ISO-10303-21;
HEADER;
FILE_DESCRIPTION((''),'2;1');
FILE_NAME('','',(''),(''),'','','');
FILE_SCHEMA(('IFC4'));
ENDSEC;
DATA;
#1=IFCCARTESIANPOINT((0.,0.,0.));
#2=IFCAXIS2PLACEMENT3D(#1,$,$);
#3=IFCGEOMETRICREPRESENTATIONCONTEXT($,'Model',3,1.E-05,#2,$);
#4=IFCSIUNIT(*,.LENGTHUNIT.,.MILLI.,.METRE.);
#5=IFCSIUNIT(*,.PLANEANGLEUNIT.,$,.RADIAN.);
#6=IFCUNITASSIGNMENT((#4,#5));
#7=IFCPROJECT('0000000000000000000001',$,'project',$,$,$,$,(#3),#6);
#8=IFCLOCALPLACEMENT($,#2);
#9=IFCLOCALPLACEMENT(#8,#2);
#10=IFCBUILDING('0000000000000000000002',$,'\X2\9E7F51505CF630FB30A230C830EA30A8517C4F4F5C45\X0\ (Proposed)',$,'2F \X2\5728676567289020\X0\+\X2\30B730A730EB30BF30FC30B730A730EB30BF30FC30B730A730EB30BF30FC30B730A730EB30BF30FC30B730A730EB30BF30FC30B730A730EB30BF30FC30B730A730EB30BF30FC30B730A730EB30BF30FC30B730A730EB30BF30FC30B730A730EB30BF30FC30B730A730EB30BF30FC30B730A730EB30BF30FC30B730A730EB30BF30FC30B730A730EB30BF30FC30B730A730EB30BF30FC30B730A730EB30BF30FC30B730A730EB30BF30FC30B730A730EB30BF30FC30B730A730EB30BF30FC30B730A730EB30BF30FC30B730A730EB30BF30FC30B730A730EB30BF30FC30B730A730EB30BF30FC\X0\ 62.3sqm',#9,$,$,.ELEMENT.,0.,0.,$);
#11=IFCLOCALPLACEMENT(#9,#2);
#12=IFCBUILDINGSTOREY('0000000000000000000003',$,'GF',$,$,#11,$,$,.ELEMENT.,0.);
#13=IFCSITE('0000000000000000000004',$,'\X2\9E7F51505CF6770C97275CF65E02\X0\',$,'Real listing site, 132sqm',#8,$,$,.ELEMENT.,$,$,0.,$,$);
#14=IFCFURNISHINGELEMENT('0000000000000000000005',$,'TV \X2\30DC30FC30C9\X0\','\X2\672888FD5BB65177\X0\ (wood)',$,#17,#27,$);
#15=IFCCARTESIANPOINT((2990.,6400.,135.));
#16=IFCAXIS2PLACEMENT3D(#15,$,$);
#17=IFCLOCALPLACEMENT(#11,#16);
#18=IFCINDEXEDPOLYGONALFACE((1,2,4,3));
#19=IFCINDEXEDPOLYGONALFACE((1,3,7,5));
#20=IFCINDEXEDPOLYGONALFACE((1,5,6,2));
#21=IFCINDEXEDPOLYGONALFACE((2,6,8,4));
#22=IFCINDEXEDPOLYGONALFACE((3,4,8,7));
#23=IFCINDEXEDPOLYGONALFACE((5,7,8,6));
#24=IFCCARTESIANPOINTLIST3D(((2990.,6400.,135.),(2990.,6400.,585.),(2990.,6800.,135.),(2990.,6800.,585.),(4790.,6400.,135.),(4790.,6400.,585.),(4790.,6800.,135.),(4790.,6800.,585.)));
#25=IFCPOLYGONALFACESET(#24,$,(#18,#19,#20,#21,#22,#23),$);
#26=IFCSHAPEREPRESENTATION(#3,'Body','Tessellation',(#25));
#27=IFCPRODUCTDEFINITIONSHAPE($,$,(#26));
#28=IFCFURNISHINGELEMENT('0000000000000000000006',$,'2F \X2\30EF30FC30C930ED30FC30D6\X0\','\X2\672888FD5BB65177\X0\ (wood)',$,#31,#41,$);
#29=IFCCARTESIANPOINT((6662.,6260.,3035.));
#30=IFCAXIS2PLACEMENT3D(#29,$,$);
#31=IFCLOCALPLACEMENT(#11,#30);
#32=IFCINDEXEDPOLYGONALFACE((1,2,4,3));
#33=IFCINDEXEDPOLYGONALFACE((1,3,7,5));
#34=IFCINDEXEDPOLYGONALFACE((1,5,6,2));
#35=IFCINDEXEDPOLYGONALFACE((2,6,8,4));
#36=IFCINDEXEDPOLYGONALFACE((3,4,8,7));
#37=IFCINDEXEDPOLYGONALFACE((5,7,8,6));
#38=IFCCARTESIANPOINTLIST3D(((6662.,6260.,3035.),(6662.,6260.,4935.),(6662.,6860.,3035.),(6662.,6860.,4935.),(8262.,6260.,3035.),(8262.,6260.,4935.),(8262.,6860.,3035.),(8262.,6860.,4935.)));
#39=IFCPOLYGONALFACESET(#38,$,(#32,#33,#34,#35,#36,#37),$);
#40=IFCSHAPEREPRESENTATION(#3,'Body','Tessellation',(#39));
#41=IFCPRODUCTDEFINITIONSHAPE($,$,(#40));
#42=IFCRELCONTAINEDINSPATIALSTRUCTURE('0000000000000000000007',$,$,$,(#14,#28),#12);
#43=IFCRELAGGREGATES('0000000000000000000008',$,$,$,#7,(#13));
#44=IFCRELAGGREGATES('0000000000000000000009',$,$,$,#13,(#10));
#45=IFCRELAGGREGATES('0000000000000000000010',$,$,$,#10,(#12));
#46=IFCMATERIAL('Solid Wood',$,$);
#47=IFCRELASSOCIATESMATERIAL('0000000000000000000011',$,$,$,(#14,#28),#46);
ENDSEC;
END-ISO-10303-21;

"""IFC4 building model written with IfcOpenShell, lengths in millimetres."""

from ifc_helpers import new_model, si_unit, frame, frame_2d, origin, place, context, project, spatial, rectangle, extrude, material, element, save


model = new_model("IFC4")

# Units and contexts
model_context = context("Model", 3, precision=1e-05, world=origin())
ifc_project = project(units=[si_unit("LENGTHUNIT", "METRE", prefix="MILLI"), si_unit("PLANEANGLEUNIT", "RADIAN")], contexts=[model_context])

# Site, building, storey
site_placement = place(None, origin())
site = spatial("IfcSite", under=ifc_project, at=site_placement, Name="鹿児島県霧島市", ObjectType="Real listing site, 132sqm", CompositionType="ELEMENT", RefElevation=0.0)
building_placement = place(site_placement, origin())
building = spatial("IfcBuilding", under=site, at=building_placement, Name="鹿児島・アトリエ兼住居 (Proposed)", ObjectType="2F 在来木造+シェルターシェルターシェルターシェルターシェルターシェルターシェルターシェルターシェルターシェルターシェルターシェルターシェルターシェルターシェルターシェルターシェルターシェルターシェルターシェルターシェルターシェルターシェルター 62.3sqm", CompositionType="ELEMENT", ElevationOfRefHeight=0.0, ElevationOfTerrain=0.0)
storey_placement = place(building_placement, origin())
storey = spatial("IfcBuildingStorey", under=building, at=storey_placement, Name="GF", CompositionType="ELEMENT", Elevation=0.0)

# Shared definitions
ifc_material_1 = material(Name="Solid Wood")

# Furnishing elements
furnishing_1_placement = place(storey_placement, frame((2990.0, 6400.0, 135.0)))
element("IfcFurnishingElement", 1, at=furnishing_1_placement, inside=storey, material=ifc_material_1, Name="TV ボード", Description="木製家具 (wood)", context=model_context, shape_type="SweptSolid", body=[
    extrude(rectangle(XDim=1800.0, YDim=400.0, at=frame_2d((900.0, 200.0))), frame((2990.0, 6400.0, 135.0)), (0.0, 0.0, 1.0), 450.0),
])
furnishing_2_placement = place(storey_placement, frame((6662.0, 6260.0, 3035.0)))
element("IfcFurnishingElement", 2, at=furnishing_2_placement, inside=storey, material=ifc_material_1, Name="2F ワードローブ", Description="木製家具 (wood)", context=model_context, shape_type="SweptSolid", body=[
    extrude(rectangle(XDim=1600.0, YDim=600.0, at=frame_2d((800.0, 300.0))), frame((6662.0, 6260.0, 3035.0)), (0.0, 0.0, 1.0), 1900.0),
])

save(model, "model.ifc")
